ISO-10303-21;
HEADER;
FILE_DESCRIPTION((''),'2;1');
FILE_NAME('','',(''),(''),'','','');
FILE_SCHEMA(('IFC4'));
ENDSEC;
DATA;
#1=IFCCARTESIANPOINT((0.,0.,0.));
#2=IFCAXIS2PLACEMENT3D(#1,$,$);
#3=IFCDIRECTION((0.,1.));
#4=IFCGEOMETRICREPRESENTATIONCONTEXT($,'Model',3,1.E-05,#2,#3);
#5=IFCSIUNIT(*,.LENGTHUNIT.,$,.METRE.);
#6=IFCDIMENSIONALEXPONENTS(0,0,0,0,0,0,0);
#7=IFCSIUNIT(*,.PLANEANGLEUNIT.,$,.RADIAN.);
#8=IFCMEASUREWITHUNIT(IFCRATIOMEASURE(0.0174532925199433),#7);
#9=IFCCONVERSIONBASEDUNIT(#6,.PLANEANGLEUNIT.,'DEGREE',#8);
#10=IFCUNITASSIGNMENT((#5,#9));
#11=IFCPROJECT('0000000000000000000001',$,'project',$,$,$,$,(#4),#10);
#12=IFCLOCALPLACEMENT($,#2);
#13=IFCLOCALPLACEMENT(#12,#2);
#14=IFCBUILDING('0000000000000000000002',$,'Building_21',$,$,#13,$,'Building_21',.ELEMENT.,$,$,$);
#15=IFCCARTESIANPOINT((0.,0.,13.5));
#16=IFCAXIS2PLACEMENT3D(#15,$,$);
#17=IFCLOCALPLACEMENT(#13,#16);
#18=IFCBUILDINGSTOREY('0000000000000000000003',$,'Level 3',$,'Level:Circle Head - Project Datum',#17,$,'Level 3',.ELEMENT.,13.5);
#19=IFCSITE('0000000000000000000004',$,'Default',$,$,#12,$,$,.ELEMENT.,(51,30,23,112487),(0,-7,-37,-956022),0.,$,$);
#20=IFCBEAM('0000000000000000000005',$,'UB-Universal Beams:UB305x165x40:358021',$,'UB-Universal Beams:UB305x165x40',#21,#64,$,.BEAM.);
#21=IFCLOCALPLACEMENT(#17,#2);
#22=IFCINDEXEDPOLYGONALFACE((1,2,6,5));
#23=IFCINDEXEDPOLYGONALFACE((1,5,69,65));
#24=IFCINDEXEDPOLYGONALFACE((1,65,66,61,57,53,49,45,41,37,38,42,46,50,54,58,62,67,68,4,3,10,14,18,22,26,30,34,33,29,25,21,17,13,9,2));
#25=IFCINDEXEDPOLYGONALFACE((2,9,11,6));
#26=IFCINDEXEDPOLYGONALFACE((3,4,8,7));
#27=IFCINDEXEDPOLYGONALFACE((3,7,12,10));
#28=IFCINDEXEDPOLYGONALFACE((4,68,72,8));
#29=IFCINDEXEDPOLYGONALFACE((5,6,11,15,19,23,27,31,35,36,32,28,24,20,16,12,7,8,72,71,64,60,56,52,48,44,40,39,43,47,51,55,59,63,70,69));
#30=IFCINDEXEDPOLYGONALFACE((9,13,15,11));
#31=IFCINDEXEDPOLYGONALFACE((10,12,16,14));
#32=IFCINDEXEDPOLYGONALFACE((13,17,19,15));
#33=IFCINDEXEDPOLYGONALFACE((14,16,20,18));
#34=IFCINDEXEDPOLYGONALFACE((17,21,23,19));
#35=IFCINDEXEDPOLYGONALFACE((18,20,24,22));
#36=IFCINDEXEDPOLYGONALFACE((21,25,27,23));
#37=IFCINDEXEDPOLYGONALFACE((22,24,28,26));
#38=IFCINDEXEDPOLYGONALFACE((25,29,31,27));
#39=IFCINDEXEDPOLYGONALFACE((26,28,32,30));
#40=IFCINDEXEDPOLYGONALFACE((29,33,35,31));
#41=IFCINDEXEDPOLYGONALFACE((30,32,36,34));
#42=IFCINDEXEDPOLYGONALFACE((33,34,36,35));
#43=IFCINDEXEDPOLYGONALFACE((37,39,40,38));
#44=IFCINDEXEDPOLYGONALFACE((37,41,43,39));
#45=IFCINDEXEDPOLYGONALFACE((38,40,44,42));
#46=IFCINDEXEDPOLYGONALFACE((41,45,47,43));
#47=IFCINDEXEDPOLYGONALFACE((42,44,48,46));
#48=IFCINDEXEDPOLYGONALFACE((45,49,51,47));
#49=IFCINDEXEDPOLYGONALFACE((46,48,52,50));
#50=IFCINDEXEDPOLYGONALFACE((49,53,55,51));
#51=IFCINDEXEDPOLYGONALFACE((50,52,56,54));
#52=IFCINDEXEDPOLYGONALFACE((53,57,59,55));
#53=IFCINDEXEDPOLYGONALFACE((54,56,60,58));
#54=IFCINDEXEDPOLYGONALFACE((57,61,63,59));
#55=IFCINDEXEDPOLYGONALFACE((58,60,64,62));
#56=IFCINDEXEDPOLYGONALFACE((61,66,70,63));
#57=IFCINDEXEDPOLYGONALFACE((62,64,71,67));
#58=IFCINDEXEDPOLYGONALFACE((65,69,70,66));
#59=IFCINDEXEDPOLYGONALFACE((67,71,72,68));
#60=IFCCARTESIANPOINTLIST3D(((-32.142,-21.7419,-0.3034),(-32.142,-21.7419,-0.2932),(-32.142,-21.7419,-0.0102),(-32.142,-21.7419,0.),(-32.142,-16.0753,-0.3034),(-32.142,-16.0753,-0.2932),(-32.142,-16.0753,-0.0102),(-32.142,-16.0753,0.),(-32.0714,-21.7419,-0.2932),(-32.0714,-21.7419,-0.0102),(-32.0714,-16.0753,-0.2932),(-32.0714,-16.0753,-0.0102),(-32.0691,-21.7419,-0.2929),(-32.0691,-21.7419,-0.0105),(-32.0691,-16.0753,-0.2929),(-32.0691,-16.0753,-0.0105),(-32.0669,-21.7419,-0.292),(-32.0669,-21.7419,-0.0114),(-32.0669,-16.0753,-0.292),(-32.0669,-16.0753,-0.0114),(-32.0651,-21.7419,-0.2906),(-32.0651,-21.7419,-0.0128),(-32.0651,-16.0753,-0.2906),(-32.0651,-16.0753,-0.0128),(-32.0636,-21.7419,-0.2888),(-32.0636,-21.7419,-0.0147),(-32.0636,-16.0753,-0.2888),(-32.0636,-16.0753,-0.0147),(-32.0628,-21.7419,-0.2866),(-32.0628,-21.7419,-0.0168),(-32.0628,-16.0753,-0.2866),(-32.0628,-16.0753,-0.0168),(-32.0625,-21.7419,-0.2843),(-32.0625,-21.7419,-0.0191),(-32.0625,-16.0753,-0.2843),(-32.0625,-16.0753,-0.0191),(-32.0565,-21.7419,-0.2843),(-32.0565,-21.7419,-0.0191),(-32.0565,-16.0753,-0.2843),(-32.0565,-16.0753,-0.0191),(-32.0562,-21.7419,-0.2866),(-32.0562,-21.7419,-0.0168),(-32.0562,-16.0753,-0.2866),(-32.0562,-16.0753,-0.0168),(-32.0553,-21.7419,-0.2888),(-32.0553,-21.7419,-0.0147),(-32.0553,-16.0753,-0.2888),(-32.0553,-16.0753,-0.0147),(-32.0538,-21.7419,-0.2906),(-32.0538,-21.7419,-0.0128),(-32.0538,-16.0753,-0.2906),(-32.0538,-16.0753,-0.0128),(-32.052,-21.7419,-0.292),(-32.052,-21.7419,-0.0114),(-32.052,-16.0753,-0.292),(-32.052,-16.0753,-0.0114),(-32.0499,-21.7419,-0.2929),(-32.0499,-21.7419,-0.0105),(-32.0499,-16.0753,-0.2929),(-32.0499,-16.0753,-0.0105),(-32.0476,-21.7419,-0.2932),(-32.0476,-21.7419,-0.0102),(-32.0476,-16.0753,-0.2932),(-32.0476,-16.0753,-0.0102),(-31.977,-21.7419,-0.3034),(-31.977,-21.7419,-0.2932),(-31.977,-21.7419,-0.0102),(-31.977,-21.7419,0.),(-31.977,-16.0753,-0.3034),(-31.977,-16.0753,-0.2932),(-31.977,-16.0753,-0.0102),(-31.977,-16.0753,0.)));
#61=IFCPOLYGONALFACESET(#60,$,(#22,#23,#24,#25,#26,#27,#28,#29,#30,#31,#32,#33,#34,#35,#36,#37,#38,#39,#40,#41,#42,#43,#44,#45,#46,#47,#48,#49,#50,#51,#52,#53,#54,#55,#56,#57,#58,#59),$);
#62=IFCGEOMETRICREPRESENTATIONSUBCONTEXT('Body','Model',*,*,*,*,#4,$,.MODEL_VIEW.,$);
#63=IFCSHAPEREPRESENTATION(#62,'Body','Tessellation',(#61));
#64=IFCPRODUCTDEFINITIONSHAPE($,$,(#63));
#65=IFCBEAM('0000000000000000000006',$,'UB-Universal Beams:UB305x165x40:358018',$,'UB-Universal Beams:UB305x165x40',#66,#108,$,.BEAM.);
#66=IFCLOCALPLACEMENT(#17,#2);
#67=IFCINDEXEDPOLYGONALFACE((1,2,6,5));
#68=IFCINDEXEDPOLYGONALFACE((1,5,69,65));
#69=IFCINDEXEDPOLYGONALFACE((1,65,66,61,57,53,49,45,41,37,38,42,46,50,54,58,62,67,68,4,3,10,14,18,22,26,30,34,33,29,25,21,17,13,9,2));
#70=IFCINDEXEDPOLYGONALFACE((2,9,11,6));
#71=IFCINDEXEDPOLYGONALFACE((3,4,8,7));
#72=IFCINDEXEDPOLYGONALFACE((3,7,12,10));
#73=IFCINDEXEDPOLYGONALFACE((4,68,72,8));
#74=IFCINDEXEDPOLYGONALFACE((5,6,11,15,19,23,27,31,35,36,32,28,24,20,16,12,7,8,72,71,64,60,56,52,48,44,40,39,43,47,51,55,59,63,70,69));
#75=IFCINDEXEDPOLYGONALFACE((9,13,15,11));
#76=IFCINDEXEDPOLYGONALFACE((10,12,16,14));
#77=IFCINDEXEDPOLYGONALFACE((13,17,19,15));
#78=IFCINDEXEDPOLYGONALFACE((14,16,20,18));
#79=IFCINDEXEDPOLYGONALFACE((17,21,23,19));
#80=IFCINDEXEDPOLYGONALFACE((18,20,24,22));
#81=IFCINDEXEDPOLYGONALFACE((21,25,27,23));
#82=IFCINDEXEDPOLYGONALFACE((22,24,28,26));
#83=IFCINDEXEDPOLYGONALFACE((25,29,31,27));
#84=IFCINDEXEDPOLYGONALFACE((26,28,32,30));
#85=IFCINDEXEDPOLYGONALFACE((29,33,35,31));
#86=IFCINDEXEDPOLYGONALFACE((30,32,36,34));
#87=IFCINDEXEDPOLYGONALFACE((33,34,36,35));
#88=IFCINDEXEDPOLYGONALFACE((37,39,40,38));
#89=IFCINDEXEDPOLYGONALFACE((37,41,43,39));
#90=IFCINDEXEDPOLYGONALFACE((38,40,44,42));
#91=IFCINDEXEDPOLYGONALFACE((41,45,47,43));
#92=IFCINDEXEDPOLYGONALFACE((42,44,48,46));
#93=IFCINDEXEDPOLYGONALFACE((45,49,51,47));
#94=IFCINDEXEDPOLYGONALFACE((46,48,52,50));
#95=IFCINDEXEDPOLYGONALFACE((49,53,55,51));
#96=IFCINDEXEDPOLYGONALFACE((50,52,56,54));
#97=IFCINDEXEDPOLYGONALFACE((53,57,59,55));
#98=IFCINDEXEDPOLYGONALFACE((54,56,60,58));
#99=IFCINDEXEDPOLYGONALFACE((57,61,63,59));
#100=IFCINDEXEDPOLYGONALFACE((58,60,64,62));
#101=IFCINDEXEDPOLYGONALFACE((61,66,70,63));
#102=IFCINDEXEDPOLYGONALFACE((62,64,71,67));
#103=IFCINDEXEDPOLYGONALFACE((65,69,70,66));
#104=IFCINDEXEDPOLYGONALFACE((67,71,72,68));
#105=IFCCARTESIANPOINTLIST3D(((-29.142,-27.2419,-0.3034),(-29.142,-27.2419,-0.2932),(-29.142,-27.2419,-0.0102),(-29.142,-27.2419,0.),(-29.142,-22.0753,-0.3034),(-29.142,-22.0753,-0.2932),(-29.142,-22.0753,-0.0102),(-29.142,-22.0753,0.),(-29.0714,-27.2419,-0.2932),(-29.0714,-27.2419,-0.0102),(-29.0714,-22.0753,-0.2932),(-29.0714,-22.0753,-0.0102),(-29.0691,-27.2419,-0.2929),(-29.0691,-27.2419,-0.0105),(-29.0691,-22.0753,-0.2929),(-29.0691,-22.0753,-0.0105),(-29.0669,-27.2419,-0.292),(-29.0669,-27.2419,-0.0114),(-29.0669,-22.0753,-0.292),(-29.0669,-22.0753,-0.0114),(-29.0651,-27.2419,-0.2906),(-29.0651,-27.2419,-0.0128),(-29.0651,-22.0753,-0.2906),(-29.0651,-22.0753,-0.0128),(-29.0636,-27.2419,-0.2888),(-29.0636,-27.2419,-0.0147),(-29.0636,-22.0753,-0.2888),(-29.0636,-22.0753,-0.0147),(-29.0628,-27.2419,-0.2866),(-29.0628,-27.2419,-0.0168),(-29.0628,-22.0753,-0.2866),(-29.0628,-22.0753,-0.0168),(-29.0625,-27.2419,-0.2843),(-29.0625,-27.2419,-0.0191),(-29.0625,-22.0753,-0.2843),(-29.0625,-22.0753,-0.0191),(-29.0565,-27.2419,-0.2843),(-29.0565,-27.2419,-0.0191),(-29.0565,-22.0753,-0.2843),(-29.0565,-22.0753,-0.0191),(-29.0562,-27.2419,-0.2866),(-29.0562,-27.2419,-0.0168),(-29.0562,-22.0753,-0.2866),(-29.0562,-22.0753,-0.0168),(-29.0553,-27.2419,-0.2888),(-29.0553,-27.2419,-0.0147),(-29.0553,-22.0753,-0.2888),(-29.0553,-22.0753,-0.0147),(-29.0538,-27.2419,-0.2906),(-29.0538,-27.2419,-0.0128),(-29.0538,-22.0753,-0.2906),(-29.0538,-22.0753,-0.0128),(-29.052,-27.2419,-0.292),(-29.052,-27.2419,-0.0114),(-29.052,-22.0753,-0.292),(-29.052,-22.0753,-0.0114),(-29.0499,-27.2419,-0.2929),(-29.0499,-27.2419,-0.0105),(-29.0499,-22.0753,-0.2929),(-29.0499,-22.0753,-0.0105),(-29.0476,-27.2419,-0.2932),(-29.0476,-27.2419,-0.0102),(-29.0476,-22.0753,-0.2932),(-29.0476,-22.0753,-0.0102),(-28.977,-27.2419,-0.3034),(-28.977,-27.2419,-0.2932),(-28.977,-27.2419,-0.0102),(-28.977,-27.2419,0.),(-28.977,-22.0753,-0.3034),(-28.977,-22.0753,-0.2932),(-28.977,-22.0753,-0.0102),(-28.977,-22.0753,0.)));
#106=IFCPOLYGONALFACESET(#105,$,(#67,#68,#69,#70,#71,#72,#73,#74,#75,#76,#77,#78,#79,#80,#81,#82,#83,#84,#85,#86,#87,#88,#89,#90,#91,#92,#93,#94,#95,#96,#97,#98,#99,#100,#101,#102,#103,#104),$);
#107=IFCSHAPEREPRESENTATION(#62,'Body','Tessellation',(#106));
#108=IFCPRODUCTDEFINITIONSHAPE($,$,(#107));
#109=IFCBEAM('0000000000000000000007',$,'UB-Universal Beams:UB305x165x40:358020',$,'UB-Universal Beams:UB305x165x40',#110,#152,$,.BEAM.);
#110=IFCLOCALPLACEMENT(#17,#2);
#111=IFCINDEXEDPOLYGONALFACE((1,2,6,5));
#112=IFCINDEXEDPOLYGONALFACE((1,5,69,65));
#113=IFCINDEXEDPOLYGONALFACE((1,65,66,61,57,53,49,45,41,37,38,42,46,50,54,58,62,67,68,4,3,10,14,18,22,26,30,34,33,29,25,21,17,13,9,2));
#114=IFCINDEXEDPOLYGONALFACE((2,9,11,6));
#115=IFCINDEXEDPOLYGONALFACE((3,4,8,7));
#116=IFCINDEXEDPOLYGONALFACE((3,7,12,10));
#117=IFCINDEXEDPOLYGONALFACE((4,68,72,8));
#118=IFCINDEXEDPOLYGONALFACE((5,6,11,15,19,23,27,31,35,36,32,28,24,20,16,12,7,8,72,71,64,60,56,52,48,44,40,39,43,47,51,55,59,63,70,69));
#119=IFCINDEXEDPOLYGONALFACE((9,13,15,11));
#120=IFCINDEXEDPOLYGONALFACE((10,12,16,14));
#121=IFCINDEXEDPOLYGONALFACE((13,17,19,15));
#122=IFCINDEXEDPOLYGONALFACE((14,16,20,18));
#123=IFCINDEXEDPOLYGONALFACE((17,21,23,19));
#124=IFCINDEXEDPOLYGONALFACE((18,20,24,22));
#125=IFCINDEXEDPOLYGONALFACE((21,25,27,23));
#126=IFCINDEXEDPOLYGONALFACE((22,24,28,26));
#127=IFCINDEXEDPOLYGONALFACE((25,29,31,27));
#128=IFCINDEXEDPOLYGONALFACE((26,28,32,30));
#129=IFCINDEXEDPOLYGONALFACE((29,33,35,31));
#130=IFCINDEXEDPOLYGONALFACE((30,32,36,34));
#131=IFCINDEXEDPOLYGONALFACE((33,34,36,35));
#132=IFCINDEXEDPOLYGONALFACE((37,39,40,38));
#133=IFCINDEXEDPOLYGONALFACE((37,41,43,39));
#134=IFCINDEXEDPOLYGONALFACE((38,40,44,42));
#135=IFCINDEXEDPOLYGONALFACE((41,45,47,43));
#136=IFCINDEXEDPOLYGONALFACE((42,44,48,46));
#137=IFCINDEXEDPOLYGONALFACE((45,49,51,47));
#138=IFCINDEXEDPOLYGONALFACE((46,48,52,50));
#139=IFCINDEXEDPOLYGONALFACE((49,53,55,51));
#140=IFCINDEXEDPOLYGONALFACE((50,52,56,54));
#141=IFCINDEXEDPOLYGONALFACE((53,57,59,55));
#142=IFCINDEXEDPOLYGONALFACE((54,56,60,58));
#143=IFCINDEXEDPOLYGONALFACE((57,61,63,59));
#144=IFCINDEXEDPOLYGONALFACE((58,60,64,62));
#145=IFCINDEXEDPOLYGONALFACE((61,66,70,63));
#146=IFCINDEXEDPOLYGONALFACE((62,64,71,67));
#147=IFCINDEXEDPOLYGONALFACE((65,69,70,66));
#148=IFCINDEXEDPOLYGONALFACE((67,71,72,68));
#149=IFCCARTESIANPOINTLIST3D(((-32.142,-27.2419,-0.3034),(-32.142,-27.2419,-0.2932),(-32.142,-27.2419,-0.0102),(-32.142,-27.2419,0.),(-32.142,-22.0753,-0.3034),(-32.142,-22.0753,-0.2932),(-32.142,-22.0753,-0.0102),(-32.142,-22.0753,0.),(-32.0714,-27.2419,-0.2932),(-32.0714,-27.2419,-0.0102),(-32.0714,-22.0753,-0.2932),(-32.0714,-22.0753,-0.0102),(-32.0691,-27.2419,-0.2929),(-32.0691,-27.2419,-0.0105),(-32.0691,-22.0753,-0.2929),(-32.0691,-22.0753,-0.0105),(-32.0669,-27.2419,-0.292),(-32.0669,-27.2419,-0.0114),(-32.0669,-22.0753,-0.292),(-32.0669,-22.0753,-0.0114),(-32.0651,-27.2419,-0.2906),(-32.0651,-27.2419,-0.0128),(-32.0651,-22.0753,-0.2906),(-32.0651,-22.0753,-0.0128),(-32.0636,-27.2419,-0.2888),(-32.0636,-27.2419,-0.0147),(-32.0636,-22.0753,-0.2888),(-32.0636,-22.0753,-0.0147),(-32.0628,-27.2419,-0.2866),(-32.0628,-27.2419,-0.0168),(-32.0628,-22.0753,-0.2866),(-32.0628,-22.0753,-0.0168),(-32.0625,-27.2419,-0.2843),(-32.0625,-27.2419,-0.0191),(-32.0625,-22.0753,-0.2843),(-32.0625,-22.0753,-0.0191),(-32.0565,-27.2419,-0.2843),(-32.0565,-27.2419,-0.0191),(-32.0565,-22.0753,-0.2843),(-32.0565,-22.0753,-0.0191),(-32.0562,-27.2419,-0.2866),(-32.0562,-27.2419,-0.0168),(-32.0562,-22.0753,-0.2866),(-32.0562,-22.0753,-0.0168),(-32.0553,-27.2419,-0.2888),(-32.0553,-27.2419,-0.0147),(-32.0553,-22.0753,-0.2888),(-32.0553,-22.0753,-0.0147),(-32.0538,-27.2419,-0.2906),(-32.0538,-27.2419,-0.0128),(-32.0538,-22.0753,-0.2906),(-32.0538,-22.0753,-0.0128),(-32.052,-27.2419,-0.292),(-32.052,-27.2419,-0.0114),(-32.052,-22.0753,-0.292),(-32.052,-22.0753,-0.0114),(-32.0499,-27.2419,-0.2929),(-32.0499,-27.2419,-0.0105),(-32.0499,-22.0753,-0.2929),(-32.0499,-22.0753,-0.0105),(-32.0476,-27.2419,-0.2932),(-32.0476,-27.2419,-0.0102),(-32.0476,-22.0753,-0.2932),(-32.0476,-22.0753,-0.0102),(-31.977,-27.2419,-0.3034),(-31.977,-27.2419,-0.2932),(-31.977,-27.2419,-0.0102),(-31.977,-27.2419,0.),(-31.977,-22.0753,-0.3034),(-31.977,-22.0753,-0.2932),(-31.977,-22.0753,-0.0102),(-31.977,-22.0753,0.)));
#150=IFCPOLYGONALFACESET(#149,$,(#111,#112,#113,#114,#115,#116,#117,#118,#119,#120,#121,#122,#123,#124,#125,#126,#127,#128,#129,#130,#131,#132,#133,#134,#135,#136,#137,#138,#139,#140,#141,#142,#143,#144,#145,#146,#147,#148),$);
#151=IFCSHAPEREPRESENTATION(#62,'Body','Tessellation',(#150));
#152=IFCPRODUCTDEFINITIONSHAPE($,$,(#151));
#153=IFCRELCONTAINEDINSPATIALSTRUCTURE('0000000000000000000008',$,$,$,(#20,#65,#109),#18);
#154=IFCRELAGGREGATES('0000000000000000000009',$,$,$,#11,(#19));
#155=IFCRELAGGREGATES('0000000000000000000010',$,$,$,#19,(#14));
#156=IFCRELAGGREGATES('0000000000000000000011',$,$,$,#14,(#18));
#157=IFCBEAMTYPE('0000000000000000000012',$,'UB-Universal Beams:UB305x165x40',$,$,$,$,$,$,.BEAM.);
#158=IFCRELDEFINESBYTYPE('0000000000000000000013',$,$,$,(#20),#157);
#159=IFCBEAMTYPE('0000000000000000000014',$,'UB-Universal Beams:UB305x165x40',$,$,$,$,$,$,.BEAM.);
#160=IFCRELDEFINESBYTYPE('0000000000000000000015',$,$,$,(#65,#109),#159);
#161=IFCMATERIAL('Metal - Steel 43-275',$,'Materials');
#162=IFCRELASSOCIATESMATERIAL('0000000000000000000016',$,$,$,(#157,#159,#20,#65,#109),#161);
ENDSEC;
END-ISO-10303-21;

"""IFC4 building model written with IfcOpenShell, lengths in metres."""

from ifc_helpers import new_model, entity, si_unit, converted_unit, direction, frame, frame_2d, origin, place, context, subcontext, project, spatial, polyline, circle_curve, parameter, trimmed, segment, composite_curve, i_section, outline, extrude, source, transform, mapped, material, material_profile, profile_set, profile_usage, type_object, type_shapes, element, save


model = new_model("IFC4")

# Units and contexts
model_context = context("Model", 3, precision=1e-05, world=origin(), true_north=direction((0.0, 1.0)))
body_context = subcontext(model_context, "Body", "Model", "MODEL_VIEW")
ifc_project = project(units=[si_unit("LENGTHUNIT", "METRE"), converted_unit("PLANEANGLEUNIT", "DEGREE", entity("IfcRatioMeasure", 0.0174532925199433), si_unit("PLANEANGLEUNIT", "RADIAN"), dimensions=[0, 0, 0, 0, 0, 0, 0])], contexts=[model_context])

# Site, building, storey
site_placement = place(None, origin())
site = spatial("IfcSite", under=ifc_project, at=site_placement, Name="Default", CompositionType="ELEMENT", RefLatitude=(51, 30, 23, 112487), RefLongitude=(0, -7, -37, -956022), RefElevation=0.0)
building_placement = place(site_placement, origin())
building = spatial("IfcBuilding", under=site, at=building_placement, Name="Building_21", LongName="Building_21", CompositionType="ELEMENT")
storey_placement = place(building_placement, frame((0.0, 0.0, 13.5)))
storey = spatial("IfcBuildingStorey", under=building, at=storey_placement, Name="Level 3", ObjectType="Level:Circle Head - Project Datum", LongName="Level 3", CompositionType="ELEMENT", Elevation=13.5)

# Shared definitions
ifc_material_1 = material(Name="Metal - Steel 43-275", Category="Materials")

# Beams
ifc_material_profile_1 = material_profile(ifc_material_1, outline(composite_curve([segment(polyline([(0.0119, -0.1415, 0.0), (0.0825, -0.1415, 0.0)]), True, "CONTINUOUS"), segment(polyline([(0.0825, -0.1415, 0.0), (0.0825, -0.1517, 0.0)]), True, "CONTINUOUS"), segment(polyline([(0.0825, -0.1517, 0.0), (-0.0825, -0.1517, 0.0)]), True, "CONTINUOUS"), segment(polyline([(-0.0825, -0.1517, 0.0), (-0.0825, -0.1415, 0.0)]), True, "CONTINUOUS"), segment(polyline([(-0.0825, -0.1415, 0.0), (-0.0119, -0.1415, 0.0)]), True, "CONTINUOUS"), segment(trimmed(circle_curve(frame((-0.0119, -0.1326, 0.0), z_axis=(0.0, 0.0, 1.0), x_axis=(-1.0, 0.0, 0.0)), 0.0089), [parameter(90.0)], [parameter(180.0)], True, "PARAMETER"), True, "CONTINUOUS"), segment(polyline([(-0.003, -0.1326, 0.0), (-0.003, 0.1326, 0.0)]), True, "CONTINUOUS"), segment(trimmed(circle_curve(frame((-0.0119, 0.1326, 0.0), z_axis=(0.0, 0.0, 1.0), x_axis=(-1.0, 0.0, 0.0)), 0.0089), [parameter(180.0)], [parameter(270.0)], True, "PARAMETER"), True, "CONTINUOUS"), segment(polyline([(-0.0119, 0.1415, 0.0), (-0.0825, 0.1415, 0.0)]), True, "CONTINUOUS"), segment(polyline([(-0.0825, 0.1415, 0.0), (-0.0825, 0.1517, 0.0)]), True, "CONTINUOUS"), segment(polyline([(-0.0825, 0.1517, 0.0), (0.0825, 0.1517, 0.0)]), True, "CONTINUOUS"), segment(polyline([(0.0825, 0.1517, 0.0), (0.0825, 0.1415, 0.0)]), True, "CONTINUOUS"), segment(polyline([(0.0825, 0.1415, 0.0), (0.0119, 0.1415, 0.0)]), True, "CONTINUOUS"), segment(trimmed(circle_curve(frame((0.0119, 0.1326, 0.0), z_axis=(0.0, 0.0, 1.0), x_axis=(-1.0, 0.0, 0.0)), 0.0089), [parameter(270.0)], [parameter(0.0)], True, "PARAMETER"), True, "CONTINUOUS"), segment(polyline([(0.003, 0.1326, 0.0), (0.003, -0.1326, 0.0)]), True, "CONTINUOUS"), segment(trimmed(circle_curve(frame((0.0119, -0.1326, 0.0), z_axis=(0.0, 0.0, 1.0), x_axis=(-1.0, 0.0, 0.0)), 0.0089), [parameter(0.0)], [parameter(90.0)], True, "PARAMETER"), True, "CONTINUOUS")], self_intersect=False), kind="CURVE"), Name="UB305x165x40")
ifc_material_profile_2 = material_profile(ifc_material_1, outline(composite_curve([segment(polyline([(-1.3346, 0.0825, -0.1415), (-1.3346, 0.0825, -0.1517)]), True, "CONTINUOUS"), segment(polyline([(-1.3346, 0.0825, -0.1517), (-1.3346, -0.0825, -0.1517)]), True, "CONTINUOUS"), segment(polyline([(-1.3346, -0.0825, -0.1517), (-1.3346, -0.0825, -0.1415)]), True, "CONTINUOUS"), segment(polyline([(-1.3346, -0.0825, -0.1415), (-1.3346, -0.003, -0.1415)]), True, "CONTINUOUS"), segment(polyline([(-1.3346, -0.003, -0.1415), (-1.3346, -0.003, 0.1415)]), True, "CONTINUOUS"), segment(polyline([(-1.3346, -0.003, 0.1415), (-1.3346, -0.0825, 0.1415)]), True, "CONTINUOUS"), segment(polyline([(-1.3346, -0.0825, 0.1415), (-1.3346, -0.0825, 0.1517)]), True, "CONTINUOUS"), segment(polyline([(-1.3346, -0.0825, 0.1517), (-1.3346, 0.0825, 0.1517)]), True, "CONTINUOUS"), segment(polyline([(-1.3346, 0.0825, 0.1517), (-1.3346, 0.0825, 0.1415)]), True, "CONTINUOUS"), segment(polyline([(-1.3346, 0.0825, 0.1415), (-1.3346, 0.003, 0.1415)]), True, "CONTINUOUS"), segment(polyline([(-1.3346, 0.003, 0.1415), (-1.3346, 0.003, -0.1415)]), True, "CONTINUOUS"), segment(polyline([(-1.3346, 0.003, -0.1415), (-1.3346, 0.0825, -0.1415)]), True, "CONTINUOUS")], self_intersect=False), kind="CURVE"), Name="UB305x165x40")
ifc_profile_set_1 = profile_set([ifc_material_profile_1, ifc_material_profile_2], Name="UB305x165x40")
beam_type_1 = type_object("IfcBeamType", Name="UB-Universal Beams:UB305x165x40", PredefinedType="BEAM", material=ifc_profile_set_1)
shared_shape_1 = source(origin(), body_context, "Body", "SweptSolid", [
    extrude(i_section(OverallWidth=0.165, OverallDepth=0.3034, WebThickness=0.006, FlangeThickness=0.0102, FilletRadius=0.0089, at=frame_2d((0.0, 0.0), x_axis=(0.0, 1.0))), frame((-2.8333, 0.0, 0.0), z_axis=(1.0, 0.0, 0.0), x_axis=(0.0, 0.0, -1.0)), (0.0, 0.0, 1.0), 5.6666),
])
type_shapes(beam_type_1, [shared_shape_1])
ifc_profile_usage_1 = profile_usage(ifc_profile_set_1, cardinal=8)
beam_1_placement = place(storey_placement, frame((-32.0595, -18.9086, -0.1517), z_axis=(0.0, 0.0, 1.0), x_axis=(0.0, -1.0, 0.0)))
element("IfcBeam", 1, at=beam_1_placement, inside=storey, type_object=beam_type_1, material=ifc_profile_usage_1, Name="UB-Universal Beams:UB305x165x40:358021", ObjectType="UB-Universal Beams:UB305x165x40", PredefinedType="BEAM", context=body_context, shape_type="MappedRepresentation", body=[
    mapped(shared_shape_1, transform((0.0, 0.0, 0.0), scale=1.0)),
])
ifc_profile_usage_2 = profile_usage(ifc_profile_set_1, cardinal=8)
beam_type_2 = type_object("IfcBeamType", Name="UB-Universal Beams:UB305x165x40", PredefinedType="BEAM", material=ifc_profile_set_1)
shared_shape_2 = source(origin(), body_context, "Body", "SweptSolid", [
    extrude(i_section(OverallWidth=0.165, OverallDepth=0.3034, WebThickness=0.006, FlangeThickness=0.0102, FilletRadius=0.0089, at=frame_2d((0.0, 0.0), x_axis=(0.0, 1.0))), frame((-2.5833, 0.0, 0.0), z_axis=(1.0, 0.0, 0.0), x_axis=(0.0, 0.0, -1.0)), (0.0, 0.0, 1.0), 5.1666),
])
type_shapes(beam_type_2, [shared_shape_2])
beam_2_placement = place(storey_placement, frame((-29.0595, -24.6586, -0.1517), z_axis=(0.0, 0.0, 1.0), x_axis=(0.0, 1.0, 0.0)))
element("IfcBeam", 2, at=beam_2_placement, inside=storey, type_object=beam_type_2, material=ifc_profile_usage_2, Name="UB-Universal Beams:UB305x165x40:358018", ObjectType="UB-Universal Beams:UB305x165x40", PredefinedType="BEAM", context=body_context, shape_type="MappedRepresentation", body=[
    mapped(shared_shape_2, transform((0.0, 0.0, 0.0), scale=1.0)),
])
ifc_profile_usage_3 = profile_usage(ifc_profile_set_1, cardinal=8)
beam_3_placement = place(storey_placement, frame((-32.0595, -24.6586, -0.1517), z_axis=(0.0, 0.0, 1.0), x_axis=(0.0, 1.0, 0.0)))
element("IfcBeam", 3, at=beam_3_placement, inside=storey, type_object=beam_type_2, material=ifc_profile_usage_3, Name="UB-Universal Beams:UB305x165x40:358020", ObjectType="UB-Universal Beams:UB305x165x40", PredefinedType="BEAM", context=body_context, shape_type="MappedRepresentation", body=[
    mapped(shared_shape_2, transform((0.0, 0.0, 0.0), scale=1.0)),
])

save(model, "model.ifc")
